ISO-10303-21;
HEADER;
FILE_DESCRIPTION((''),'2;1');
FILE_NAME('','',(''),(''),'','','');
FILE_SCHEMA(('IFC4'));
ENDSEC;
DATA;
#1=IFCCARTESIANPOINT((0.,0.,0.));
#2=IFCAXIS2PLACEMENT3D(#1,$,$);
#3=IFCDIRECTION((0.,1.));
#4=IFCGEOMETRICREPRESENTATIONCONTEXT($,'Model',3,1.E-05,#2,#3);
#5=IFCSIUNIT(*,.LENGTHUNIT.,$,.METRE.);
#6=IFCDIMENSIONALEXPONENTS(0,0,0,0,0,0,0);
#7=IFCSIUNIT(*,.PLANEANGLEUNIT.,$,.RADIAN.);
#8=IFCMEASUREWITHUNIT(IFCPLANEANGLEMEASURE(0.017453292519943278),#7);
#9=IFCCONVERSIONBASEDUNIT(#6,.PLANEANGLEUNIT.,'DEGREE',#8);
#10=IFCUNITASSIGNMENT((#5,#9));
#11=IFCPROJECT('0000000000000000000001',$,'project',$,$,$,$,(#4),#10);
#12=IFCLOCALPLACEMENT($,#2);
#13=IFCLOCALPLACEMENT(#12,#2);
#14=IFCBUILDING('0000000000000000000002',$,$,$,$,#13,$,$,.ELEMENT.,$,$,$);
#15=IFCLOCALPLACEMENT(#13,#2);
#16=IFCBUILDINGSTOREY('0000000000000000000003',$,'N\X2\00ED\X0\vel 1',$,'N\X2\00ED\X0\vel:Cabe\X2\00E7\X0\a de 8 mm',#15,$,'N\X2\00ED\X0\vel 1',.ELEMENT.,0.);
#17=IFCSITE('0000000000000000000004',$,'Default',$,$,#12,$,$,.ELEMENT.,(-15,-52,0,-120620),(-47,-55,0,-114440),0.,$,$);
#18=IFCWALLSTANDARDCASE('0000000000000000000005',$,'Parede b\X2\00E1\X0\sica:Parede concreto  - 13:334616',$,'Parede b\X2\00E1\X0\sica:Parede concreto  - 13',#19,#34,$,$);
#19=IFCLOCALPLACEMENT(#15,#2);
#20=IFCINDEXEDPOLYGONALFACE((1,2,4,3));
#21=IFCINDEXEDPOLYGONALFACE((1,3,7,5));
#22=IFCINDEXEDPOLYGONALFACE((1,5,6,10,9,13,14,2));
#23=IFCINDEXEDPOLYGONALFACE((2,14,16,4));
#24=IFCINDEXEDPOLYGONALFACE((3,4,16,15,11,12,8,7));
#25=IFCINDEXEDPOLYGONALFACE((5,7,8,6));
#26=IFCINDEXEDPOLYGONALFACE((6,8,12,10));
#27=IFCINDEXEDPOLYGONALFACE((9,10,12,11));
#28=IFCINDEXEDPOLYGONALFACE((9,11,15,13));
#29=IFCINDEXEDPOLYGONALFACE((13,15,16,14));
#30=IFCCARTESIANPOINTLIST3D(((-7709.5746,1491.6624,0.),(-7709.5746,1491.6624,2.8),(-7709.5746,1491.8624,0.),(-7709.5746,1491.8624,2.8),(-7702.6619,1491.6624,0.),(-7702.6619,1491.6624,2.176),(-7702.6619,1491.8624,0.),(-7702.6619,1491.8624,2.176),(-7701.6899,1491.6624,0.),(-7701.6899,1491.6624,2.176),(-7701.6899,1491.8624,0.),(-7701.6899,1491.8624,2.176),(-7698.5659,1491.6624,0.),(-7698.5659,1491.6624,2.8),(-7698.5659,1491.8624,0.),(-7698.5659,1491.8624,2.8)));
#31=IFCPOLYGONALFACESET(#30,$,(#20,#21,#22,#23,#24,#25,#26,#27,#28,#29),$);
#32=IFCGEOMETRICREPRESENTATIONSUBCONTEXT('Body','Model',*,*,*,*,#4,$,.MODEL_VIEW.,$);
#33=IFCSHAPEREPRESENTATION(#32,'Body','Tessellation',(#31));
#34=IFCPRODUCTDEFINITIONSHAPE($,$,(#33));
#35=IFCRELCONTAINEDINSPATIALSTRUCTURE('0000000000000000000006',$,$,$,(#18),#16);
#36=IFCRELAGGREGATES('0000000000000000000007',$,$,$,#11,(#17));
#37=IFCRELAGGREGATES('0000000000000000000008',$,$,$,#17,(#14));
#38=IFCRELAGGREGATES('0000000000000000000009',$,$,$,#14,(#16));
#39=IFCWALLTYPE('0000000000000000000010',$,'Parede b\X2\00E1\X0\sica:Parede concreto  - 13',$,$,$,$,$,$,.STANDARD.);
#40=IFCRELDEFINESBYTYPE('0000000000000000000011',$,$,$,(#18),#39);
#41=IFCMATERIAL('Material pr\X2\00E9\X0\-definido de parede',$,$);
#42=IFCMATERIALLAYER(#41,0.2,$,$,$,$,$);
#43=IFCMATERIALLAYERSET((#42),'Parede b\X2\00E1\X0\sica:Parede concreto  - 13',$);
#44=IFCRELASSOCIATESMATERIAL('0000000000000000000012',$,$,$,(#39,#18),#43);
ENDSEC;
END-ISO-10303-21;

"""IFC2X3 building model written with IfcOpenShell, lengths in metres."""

from ifc_helpers import new_model, entity, si_unit, converted_unit, direction, frame, frame_2d, origin, place, context, subcontext, project, spatial, rectangle, extrude, material, layer, layer_set, layer_usage, type_object, element, save


model = new_model("IFC2X3")

# Units and contexts
model_context = context("Model", 3, precision=1e-05, world=origin(), true_north=direction((0.0, 1.0)))
body_context = subcontext(model_context, "Body", "Model", "MODEL_VIEW")
ifc_project = project(units=[si_unit("LENGTHUNIT", "METRE"), converted_unit("PLANEANGLEUNIT", "DEGREE", entity("IfcPlaneAngleMeasure", 0.017453292519943278), si_unit("PLANEANGLEUNIT", "RADIAN"), dimensions=[0, 0, 0, 0, 0, 0, 0])], contexts=[model_context])

# Site, building, storey
site_placement = place(None, origin())
site = spatial("IfcSite", under=ifc_project, at=site_placement, Name="Default", CompositionType="ELEMENT", RefLatitude=(-15, -52, 0, -120620), RefLongitude=(-47, -55, 0, -114440), RefElevation=0.0)
building_placement = place(site_placement, origin())
building = spatial("IfcBuilding", under=site, at=building_placement, CompositionType="ELEMENT")
storey_placement = place(building_placement, origin())
storey = spatial("IfcBuildingStorey", under=building, at=storey_placement, Name="Nível 1", ObjectType="Nível:Cabeça de 8 mm", LongName="Nível 1", CompositionType="ELEMENT", Elevation=0.0)

# Wall, opening
ifc_material_1 = material(Name="Material pré-definido de parede")
ifc_layer = layer(ifc_material_1, 0.2)
ifc_layer_set = layer_set([ifc_layer], Name="Parede básica:Parede concreto  - 13")
ifc_layer_usage_1 = layer_usage(ifc_layer_set, "AXIS2", "NEGATIVE", 0.1)
wall_type = type_object("IfcWallType", Name="Parede básica:Parede concreto  - 13", PredefinedType="STANDARD", material=ifc_layer_set)
wall_1_placement = place(storey_placement, frame((-7698.5659, 1491.7624, 0.0), z_axis=(0.0, 0.0, 1.0), x_axis=(-1.0, 0.0, 0.0)))
wall_1 = element("IfcWallStandardCase", 1, at=wall_1_placement, inside=storey, type_object=wall_type, material=ifc_layer_usage_1, Name="Parede básica:Parede concreto  - 13:334616", ObjectType="Parede básica:Parede concreto  - 13", context=body_context, shape_type="SweptSolid", body=[
    extrude(rectangle(XDim=11.0087, YDim=0.2, at=frame_2d((5.5043, 0.0), x_axis=(-1.0, 0.0))), origin(), (0.0, 0.0, 1.0), 2.8),
])
opening_1_placement = place(wall_1_placement, origin())
element("IfcOpeningElement", 2, at=opening_1_placement, cuts=wall_1, ObjectType="Opening", context=body_context, shape_type="SweptSolid", body=[
    extrude(rectangle(XDim=2.176, YDim=0.972, at=frame_2d((0.0, 0.0), x_axis=(0.0, 1.0))), frame((3.61, 0.1, 1.088), z_axis=(0.0, -1.0, 0.0), x_axis=(1.0, 0.0, 0.0)), (0.0, 0.0, 1.0), 0.2),
])

save(model, "model.ifc")
